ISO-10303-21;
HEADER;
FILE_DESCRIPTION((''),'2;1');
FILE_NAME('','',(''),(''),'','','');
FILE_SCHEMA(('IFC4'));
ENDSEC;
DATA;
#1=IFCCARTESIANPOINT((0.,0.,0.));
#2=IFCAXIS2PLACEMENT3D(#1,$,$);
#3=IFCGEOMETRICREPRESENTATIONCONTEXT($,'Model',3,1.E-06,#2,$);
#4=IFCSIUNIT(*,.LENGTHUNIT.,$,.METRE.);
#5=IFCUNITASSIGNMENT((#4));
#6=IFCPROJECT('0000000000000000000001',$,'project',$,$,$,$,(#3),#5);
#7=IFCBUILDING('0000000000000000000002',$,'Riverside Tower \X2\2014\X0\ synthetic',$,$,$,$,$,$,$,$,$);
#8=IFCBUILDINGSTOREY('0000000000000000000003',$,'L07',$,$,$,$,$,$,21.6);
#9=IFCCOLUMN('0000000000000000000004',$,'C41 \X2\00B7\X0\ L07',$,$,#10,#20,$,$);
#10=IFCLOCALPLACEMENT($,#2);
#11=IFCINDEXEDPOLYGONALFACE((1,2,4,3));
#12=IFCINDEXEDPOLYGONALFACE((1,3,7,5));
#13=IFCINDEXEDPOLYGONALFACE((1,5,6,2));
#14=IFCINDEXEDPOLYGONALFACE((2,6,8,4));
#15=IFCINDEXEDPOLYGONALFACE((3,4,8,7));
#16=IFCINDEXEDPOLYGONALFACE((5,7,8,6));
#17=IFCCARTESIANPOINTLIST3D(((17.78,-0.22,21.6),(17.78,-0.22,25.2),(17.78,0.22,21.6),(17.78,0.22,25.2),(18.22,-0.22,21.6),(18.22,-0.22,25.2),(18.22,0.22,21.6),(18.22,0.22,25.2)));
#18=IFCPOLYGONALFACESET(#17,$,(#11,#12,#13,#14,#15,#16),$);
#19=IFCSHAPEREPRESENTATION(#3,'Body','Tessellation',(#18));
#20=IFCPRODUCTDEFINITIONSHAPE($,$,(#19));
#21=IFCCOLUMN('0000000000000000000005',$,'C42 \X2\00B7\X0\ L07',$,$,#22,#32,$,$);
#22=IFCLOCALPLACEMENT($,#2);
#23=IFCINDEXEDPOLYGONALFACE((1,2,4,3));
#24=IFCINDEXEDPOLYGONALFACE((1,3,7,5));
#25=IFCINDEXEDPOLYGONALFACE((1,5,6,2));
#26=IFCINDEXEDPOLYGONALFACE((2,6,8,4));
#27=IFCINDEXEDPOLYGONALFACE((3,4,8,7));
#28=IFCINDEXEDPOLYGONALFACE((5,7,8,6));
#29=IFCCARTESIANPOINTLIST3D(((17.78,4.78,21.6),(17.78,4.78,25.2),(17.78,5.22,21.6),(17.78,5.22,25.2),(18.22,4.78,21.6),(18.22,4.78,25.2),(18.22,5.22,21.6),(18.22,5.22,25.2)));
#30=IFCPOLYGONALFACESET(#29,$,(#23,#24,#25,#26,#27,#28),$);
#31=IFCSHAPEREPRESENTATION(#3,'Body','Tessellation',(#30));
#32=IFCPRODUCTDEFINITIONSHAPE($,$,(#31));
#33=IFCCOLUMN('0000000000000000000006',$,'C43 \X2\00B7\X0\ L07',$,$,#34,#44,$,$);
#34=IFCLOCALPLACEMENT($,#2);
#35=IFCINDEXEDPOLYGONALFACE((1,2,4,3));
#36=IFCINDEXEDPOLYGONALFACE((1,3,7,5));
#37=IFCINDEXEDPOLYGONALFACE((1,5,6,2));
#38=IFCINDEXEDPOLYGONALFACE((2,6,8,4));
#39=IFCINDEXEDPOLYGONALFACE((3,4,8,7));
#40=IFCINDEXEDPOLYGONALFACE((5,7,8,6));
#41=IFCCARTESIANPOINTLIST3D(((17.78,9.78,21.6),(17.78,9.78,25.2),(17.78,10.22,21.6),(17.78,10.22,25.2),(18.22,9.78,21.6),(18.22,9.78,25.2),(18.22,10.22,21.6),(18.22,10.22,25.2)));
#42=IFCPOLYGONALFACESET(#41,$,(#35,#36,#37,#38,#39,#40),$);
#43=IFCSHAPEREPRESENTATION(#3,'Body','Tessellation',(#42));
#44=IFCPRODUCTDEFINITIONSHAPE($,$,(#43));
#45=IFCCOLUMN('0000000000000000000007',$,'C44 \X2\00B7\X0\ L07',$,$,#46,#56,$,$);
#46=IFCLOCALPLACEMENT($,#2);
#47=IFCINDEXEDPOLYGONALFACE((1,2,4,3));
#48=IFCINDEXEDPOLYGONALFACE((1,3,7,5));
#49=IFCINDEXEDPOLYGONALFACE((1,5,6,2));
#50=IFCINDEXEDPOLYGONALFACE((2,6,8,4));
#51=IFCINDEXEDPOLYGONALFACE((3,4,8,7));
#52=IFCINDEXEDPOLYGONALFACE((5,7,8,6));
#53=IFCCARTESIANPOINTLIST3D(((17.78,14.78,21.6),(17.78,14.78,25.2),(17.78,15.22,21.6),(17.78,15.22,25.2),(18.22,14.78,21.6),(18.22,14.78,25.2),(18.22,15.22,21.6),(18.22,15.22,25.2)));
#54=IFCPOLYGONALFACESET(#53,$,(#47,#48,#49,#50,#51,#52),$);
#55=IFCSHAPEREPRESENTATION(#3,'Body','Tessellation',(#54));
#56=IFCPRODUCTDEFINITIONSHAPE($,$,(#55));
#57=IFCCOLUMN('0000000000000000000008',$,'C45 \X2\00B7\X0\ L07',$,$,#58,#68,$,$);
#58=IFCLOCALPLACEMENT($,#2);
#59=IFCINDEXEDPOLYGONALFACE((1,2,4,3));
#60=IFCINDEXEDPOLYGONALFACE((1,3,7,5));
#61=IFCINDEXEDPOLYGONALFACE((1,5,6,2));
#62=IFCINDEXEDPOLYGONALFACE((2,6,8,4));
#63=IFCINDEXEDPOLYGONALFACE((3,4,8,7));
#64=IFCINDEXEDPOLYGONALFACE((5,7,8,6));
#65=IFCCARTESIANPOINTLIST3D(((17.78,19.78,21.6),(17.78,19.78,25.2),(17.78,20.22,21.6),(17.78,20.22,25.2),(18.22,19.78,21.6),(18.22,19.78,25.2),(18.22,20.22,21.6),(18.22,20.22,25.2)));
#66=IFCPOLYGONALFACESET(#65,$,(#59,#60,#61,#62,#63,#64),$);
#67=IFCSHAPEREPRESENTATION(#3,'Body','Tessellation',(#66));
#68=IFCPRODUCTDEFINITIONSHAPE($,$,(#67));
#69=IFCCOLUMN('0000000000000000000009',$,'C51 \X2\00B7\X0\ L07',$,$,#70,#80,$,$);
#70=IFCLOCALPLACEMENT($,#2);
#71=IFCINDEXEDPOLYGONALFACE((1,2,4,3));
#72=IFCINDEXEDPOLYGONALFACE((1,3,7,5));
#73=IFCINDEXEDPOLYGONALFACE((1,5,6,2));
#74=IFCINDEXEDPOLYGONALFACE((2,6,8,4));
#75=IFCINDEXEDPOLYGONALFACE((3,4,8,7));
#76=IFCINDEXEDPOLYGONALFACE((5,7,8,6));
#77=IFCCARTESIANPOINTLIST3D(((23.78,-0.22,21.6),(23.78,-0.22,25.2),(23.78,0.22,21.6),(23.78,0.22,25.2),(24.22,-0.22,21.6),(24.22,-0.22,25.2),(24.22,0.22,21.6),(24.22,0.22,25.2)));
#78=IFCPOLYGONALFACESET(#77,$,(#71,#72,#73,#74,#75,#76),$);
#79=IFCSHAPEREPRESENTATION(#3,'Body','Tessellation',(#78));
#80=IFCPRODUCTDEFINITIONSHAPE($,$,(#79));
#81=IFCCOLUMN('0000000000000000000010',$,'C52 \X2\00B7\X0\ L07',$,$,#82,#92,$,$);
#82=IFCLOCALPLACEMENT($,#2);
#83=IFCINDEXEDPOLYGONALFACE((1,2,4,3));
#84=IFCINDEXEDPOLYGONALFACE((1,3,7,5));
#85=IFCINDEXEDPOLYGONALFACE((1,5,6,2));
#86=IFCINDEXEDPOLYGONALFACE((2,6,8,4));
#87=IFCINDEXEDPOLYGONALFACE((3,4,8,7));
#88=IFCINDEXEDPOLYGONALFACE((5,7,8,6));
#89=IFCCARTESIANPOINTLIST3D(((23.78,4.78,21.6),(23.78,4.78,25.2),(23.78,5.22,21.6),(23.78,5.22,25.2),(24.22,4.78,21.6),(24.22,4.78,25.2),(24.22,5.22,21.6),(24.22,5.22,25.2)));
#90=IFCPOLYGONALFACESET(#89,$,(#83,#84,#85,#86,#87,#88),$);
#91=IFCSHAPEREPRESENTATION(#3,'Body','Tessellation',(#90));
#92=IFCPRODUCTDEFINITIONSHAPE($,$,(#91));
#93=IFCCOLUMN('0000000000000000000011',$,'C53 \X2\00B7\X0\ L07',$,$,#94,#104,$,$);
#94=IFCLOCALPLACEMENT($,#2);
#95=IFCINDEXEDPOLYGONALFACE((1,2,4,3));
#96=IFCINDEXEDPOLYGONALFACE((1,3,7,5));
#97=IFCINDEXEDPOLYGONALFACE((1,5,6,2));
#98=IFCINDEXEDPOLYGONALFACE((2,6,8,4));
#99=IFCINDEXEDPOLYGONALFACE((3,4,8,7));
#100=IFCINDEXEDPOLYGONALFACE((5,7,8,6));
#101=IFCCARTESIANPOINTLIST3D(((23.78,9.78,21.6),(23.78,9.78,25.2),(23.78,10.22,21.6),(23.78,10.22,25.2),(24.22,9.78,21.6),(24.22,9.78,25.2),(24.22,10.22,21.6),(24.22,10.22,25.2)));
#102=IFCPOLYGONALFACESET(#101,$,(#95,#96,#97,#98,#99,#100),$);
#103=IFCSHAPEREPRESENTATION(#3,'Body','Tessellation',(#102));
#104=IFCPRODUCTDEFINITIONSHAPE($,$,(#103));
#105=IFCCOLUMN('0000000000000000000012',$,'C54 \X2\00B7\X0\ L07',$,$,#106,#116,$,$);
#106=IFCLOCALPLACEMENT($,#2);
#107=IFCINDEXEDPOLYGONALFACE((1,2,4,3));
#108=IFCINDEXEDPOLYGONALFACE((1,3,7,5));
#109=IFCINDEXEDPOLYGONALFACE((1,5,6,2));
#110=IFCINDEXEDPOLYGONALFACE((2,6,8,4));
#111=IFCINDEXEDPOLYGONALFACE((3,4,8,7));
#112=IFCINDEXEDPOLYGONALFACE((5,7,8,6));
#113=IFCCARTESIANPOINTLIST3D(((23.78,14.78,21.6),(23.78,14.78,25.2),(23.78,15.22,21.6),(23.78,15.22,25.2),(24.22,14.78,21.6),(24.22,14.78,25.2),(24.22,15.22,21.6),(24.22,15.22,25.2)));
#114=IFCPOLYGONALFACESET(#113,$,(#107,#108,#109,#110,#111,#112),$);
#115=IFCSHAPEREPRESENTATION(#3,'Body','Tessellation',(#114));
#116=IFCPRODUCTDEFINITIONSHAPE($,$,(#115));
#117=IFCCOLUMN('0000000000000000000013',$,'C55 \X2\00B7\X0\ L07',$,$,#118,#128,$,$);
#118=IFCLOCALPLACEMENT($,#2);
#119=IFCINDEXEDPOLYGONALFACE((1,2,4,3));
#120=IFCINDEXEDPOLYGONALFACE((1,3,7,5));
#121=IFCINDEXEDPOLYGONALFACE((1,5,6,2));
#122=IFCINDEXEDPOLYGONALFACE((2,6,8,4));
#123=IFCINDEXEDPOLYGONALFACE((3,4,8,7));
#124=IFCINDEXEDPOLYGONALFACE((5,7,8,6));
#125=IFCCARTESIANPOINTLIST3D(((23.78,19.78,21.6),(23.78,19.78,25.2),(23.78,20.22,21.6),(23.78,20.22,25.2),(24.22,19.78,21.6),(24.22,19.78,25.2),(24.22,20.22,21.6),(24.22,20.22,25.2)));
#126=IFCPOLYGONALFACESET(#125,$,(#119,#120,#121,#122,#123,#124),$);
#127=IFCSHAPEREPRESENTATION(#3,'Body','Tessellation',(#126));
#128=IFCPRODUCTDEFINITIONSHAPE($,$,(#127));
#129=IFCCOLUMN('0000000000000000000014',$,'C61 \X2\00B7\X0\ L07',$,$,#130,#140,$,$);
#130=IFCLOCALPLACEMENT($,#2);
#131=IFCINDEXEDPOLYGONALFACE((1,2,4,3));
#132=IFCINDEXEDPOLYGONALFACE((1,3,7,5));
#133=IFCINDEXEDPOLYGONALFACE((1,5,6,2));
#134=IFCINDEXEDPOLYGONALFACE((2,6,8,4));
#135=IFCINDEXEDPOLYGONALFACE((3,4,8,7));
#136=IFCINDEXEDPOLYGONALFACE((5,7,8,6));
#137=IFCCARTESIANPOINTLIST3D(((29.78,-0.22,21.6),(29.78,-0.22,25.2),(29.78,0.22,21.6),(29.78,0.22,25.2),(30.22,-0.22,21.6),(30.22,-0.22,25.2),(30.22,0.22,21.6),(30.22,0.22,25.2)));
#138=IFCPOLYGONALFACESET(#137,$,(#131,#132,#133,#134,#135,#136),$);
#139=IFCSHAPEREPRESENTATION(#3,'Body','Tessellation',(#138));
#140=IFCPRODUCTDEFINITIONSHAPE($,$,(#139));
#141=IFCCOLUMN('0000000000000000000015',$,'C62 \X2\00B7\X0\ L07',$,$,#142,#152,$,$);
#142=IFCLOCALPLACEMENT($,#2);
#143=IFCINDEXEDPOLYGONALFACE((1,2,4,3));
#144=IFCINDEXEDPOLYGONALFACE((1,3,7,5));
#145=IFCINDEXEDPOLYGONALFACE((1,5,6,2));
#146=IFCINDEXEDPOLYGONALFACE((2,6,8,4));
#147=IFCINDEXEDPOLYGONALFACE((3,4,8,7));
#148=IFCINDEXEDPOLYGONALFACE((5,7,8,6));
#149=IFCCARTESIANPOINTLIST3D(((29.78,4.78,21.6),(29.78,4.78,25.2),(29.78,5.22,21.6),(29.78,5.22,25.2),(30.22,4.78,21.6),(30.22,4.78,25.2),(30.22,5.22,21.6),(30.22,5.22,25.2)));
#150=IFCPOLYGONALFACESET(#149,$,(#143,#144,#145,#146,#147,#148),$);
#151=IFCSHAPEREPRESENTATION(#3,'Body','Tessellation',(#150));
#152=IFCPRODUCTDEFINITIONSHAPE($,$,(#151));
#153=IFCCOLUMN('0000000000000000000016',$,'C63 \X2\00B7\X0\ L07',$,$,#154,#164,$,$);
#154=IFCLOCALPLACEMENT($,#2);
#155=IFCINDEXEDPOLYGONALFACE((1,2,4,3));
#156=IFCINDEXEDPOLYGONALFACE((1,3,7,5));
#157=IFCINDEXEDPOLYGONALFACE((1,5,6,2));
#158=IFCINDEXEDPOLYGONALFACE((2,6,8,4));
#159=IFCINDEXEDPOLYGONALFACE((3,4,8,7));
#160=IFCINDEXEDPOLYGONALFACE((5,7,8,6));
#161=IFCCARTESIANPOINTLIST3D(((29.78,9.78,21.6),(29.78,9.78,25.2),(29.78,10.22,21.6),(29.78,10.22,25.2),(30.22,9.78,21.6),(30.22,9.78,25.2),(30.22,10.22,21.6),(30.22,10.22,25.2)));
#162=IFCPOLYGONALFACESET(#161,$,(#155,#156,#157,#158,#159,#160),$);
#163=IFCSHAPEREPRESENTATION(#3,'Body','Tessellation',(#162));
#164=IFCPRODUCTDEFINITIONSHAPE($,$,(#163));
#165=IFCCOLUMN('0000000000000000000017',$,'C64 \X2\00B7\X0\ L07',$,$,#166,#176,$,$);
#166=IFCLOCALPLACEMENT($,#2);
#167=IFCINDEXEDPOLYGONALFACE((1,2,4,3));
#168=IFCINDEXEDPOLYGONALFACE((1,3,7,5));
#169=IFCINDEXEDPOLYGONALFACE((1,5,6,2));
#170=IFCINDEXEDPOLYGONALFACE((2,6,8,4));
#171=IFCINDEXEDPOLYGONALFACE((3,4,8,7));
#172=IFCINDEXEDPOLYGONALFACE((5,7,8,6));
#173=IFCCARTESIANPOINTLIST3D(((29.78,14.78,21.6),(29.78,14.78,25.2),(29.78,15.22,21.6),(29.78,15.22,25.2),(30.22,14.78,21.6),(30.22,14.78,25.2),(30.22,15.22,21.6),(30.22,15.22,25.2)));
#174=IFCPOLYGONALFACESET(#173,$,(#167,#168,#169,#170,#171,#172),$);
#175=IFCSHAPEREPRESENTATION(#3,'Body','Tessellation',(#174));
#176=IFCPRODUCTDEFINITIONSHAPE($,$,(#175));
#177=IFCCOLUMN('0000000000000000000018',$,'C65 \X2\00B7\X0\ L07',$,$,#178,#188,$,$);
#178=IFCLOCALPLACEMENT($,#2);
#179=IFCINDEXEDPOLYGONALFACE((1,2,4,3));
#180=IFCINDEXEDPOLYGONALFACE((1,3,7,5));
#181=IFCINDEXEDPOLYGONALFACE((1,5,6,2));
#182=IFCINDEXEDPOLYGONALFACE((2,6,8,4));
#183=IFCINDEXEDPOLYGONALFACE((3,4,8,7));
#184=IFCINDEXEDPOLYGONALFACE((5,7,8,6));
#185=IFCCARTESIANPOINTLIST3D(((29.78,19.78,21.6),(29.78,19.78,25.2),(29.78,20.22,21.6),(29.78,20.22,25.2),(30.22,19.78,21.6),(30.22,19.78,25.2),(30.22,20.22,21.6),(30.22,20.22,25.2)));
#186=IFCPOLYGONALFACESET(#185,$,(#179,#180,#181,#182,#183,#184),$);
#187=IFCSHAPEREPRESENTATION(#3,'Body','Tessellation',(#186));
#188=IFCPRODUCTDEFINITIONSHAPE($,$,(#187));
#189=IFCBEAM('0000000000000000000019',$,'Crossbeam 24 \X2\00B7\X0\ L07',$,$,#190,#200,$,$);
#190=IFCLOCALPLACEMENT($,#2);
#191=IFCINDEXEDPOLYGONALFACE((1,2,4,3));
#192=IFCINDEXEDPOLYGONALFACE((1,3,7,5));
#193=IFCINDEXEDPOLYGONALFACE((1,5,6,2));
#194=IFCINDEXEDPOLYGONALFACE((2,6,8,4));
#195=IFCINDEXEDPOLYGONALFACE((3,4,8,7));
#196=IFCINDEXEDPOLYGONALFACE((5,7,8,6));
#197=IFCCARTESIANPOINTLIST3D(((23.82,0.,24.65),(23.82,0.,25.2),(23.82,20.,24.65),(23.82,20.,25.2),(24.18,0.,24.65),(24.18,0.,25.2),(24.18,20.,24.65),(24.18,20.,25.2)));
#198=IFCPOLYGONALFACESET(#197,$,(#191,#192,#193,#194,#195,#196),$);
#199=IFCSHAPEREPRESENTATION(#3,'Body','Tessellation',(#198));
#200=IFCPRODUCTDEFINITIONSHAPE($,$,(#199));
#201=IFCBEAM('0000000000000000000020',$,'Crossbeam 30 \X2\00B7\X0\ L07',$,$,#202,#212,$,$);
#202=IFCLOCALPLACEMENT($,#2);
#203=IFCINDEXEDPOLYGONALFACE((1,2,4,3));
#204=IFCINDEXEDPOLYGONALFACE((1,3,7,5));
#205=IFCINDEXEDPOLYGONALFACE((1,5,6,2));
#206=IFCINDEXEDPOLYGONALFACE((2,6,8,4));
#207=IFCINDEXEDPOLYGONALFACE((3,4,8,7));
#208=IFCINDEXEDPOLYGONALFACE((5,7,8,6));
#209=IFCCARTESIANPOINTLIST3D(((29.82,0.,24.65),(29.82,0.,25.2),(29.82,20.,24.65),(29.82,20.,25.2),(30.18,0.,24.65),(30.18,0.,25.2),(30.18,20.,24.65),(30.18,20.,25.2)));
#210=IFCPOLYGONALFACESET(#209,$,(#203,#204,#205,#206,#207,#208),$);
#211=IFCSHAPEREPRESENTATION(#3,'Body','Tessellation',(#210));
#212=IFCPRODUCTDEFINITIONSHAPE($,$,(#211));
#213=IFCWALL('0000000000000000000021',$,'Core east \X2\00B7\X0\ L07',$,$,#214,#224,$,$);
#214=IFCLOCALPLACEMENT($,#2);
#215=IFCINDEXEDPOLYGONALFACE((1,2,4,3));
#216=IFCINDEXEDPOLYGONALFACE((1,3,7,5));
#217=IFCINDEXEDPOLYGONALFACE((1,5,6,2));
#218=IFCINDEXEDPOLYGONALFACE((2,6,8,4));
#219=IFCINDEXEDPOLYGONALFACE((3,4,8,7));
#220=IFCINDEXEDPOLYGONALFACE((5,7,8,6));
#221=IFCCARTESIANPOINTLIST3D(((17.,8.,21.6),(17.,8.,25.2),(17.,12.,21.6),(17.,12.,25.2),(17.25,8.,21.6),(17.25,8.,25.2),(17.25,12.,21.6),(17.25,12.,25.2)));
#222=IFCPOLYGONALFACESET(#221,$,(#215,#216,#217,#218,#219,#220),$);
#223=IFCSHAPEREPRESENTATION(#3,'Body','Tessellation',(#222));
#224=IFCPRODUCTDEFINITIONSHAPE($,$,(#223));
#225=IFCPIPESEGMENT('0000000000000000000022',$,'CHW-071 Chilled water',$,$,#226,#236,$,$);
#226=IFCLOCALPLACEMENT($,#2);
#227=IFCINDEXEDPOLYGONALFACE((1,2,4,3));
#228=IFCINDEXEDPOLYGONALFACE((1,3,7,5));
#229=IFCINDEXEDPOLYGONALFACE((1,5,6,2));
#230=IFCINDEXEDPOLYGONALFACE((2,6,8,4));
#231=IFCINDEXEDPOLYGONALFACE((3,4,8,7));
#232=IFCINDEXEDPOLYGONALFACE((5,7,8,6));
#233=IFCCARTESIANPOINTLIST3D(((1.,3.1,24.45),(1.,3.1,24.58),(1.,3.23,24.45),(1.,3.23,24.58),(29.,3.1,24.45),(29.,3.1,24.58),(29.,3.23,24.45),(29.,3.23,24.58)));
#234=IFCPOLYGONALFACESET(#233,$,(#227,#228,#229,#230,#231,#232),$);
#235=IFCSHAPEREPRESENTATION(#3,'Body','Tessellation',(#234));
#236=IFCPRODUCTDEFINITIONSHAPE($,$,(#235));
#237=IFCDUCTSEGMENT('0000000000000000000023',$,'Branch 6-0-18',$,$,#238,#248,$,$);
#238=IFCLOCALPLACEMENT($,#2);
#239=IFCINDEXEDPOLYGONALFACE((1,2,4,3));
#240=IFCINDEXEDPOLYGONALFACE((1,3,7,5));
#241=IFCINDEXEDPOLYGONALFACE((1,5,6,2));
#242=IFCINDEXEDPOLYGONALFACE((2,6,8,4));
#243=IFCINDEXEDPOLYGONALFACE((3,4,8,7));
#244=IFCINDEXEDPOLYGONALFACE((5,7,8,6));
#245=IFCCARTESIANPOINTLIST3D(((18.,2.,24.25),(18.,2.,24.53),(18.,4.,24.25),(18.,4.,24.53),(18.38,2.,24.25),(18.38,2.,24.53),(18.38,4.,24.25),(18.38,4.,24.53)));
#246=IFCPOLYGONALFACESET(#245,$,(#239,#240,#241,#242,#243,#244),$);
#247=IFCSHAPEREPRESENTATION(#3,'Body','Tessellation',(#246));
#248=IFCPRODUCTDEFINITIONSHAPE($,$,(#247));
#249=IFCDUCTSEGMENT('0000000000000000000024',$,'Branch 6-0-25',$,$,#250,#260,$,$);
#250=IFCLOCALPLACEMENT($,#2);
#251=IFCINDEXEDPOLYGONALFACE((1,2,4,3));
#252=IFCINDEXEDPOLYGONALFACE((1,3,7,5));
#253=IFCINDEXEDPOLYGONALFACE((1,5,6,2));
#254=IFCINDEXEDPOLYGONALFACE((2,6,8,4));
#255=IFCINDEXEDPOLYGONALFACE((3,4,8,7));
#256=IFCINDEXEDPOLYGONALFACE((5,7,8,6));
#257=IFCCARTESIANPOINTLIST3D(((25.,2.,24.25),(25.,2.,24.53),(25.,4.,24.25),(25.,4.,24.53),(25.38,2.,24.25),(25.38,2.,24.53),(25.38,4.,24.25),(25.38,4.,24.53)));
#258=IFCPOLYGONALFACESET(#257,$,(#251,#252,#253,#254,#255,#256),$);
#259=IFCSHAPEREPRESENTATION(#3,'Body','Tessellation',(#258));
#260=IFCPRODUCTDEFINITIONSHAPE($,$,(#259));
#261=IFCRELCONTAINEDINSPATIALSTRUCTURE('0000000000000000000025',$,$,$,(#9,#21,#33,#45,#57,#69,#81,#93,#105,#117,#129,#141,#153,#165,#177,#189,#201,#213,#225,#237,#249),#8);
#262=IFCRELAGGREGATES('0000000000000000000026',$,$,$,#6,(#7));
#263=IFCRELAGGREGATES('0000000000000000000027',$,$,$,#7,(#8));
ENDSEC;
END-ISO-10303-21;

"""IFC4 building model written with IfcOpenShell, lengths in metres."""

from ifc_helpers import new_model, si_unit, frame, origin, place, context, project, spatial, rectangle, extrude, element, save


model = new_model("IFC4")

# Units and contexts
model_context = context("Model", 3, precision=1e-06, world=origin())
ifc_project = project(units=[si_unit("LENGTHUNIT", "METRE")], contexts=[model_context])

# Building, storey
building = spatial("IfcBuilding", under=ifc_project, Name="Riverside Tower — synthetic")
storey = spatial("IfcBuildingStorey", under=building, Name="L07", Elevation=21.6)

# Columns
for number, where, name in (
    (1, (18.0, 0.0, 21.6), "C41 · L07"),
    (2, (18.0, 5.0, 21.6), "C42 · L07"),
    (3, (18.0, 10.0, 21.6), "C43 · L07"),
    (4, (18.0, 15.0, 21.6), "C44 · L07"),
    (5, (18.0, 20.0, 21.6), "C45 · L07"),
    (6, (24.0, 0.0, 21.6), "C51 · L07"),
    (7, (24.0, 5.0, 21.6), "C52 · L07"),
    (8, (24.0, 10.0, 21.6), "C53 · L07"),
    (9, (24.0, 15.0, 21.6), "C54 · L07"),
    (10, (24.0, 20.0, 21.6), "C55 · L07"),
    (11, (30.0, 0.0, 21.6), "C61 · L07"),
    (12, (30.0, 5.0, 21.6), "C62 · L07"),
    (13, (30.0, 10.0, 21.6), "C63 · L07"),
    (14, (30.0, 15.0, 21.6), "C64 · L07"),
    (15, (30.0, 20.0, 21.6), "C65 · L07"),
):
    element("IfcColumn", number, at=place(None, frame(where)), inside=storey, Name=name, context=model_context, shape_type="SweptSolid", body=[
        extrude(rectangle(XDim=0.44, YDim=0.44), origin(), (0.0, 0.0, 1.0), 3.6),
    ])

# Beams
for number, where, name in (
    (16, (24.0, 10.0, 24.65), "Crossbeam 24 · L07"),
    (17, (30.0, 10.0, 24.65), "Crossbeam 30 · L07"),
):
    element("IfcBeam", number, at=place(None, frame(where)), inside=storey, Name=name, context=model_context, shape_type="SweptSolid", body=[
        extrude(rectangle(XDim=0.36, YDim=20.0), origin(), (0.0, 0.0, 1.0), 0.55),
    ])

# Wall
wall_placement = place(None, frame((17.125, 10.0, 21.6)))
element("IfcWall", 18, at=wall_placement, inside=storey, Name="Core east · L07", context=model_context, shape_type="SweptSolid", body=[
    extrude(rectangle(XDim=0.25, YDim=4.0), origin(), (0.0, 0.0, 1.0), 3.6),
])

# Pipe segment
pipe_segment_1_placement = place(None, frame((15.0, 3.165, 24.45)))
element("IfcPipeSegment", 19, at=pipe_segment_1_placement, inside=storey, Name="CHW-071 Chilled water", context=model_context, shape_type="SweptSolid", body=[
    extrude(rectangle(XDim=28.0, YDim=0.13), origin(), (0.0, 0.0, 1.0), 0.13),
])

# Duct segments
for number, where, name in (
    (20, (18.19, 3.0, 24.25), "Branch 6-0-18"),
    (21, (25.19, 3.0, 24.25), "Branch 6-0-25"),
):
    element("IfcDuctSegment", number, at=place(None, frame(where)), inside=storey, Name=name, context=model_context, shape_type="SweptSolid", body=[
        extrude(rectangle(XDim=0.38, YDim=2.0), origin(), (0.0, 0.0, 1.0), 0.28),
    ])

save(model, "model.ifc")
